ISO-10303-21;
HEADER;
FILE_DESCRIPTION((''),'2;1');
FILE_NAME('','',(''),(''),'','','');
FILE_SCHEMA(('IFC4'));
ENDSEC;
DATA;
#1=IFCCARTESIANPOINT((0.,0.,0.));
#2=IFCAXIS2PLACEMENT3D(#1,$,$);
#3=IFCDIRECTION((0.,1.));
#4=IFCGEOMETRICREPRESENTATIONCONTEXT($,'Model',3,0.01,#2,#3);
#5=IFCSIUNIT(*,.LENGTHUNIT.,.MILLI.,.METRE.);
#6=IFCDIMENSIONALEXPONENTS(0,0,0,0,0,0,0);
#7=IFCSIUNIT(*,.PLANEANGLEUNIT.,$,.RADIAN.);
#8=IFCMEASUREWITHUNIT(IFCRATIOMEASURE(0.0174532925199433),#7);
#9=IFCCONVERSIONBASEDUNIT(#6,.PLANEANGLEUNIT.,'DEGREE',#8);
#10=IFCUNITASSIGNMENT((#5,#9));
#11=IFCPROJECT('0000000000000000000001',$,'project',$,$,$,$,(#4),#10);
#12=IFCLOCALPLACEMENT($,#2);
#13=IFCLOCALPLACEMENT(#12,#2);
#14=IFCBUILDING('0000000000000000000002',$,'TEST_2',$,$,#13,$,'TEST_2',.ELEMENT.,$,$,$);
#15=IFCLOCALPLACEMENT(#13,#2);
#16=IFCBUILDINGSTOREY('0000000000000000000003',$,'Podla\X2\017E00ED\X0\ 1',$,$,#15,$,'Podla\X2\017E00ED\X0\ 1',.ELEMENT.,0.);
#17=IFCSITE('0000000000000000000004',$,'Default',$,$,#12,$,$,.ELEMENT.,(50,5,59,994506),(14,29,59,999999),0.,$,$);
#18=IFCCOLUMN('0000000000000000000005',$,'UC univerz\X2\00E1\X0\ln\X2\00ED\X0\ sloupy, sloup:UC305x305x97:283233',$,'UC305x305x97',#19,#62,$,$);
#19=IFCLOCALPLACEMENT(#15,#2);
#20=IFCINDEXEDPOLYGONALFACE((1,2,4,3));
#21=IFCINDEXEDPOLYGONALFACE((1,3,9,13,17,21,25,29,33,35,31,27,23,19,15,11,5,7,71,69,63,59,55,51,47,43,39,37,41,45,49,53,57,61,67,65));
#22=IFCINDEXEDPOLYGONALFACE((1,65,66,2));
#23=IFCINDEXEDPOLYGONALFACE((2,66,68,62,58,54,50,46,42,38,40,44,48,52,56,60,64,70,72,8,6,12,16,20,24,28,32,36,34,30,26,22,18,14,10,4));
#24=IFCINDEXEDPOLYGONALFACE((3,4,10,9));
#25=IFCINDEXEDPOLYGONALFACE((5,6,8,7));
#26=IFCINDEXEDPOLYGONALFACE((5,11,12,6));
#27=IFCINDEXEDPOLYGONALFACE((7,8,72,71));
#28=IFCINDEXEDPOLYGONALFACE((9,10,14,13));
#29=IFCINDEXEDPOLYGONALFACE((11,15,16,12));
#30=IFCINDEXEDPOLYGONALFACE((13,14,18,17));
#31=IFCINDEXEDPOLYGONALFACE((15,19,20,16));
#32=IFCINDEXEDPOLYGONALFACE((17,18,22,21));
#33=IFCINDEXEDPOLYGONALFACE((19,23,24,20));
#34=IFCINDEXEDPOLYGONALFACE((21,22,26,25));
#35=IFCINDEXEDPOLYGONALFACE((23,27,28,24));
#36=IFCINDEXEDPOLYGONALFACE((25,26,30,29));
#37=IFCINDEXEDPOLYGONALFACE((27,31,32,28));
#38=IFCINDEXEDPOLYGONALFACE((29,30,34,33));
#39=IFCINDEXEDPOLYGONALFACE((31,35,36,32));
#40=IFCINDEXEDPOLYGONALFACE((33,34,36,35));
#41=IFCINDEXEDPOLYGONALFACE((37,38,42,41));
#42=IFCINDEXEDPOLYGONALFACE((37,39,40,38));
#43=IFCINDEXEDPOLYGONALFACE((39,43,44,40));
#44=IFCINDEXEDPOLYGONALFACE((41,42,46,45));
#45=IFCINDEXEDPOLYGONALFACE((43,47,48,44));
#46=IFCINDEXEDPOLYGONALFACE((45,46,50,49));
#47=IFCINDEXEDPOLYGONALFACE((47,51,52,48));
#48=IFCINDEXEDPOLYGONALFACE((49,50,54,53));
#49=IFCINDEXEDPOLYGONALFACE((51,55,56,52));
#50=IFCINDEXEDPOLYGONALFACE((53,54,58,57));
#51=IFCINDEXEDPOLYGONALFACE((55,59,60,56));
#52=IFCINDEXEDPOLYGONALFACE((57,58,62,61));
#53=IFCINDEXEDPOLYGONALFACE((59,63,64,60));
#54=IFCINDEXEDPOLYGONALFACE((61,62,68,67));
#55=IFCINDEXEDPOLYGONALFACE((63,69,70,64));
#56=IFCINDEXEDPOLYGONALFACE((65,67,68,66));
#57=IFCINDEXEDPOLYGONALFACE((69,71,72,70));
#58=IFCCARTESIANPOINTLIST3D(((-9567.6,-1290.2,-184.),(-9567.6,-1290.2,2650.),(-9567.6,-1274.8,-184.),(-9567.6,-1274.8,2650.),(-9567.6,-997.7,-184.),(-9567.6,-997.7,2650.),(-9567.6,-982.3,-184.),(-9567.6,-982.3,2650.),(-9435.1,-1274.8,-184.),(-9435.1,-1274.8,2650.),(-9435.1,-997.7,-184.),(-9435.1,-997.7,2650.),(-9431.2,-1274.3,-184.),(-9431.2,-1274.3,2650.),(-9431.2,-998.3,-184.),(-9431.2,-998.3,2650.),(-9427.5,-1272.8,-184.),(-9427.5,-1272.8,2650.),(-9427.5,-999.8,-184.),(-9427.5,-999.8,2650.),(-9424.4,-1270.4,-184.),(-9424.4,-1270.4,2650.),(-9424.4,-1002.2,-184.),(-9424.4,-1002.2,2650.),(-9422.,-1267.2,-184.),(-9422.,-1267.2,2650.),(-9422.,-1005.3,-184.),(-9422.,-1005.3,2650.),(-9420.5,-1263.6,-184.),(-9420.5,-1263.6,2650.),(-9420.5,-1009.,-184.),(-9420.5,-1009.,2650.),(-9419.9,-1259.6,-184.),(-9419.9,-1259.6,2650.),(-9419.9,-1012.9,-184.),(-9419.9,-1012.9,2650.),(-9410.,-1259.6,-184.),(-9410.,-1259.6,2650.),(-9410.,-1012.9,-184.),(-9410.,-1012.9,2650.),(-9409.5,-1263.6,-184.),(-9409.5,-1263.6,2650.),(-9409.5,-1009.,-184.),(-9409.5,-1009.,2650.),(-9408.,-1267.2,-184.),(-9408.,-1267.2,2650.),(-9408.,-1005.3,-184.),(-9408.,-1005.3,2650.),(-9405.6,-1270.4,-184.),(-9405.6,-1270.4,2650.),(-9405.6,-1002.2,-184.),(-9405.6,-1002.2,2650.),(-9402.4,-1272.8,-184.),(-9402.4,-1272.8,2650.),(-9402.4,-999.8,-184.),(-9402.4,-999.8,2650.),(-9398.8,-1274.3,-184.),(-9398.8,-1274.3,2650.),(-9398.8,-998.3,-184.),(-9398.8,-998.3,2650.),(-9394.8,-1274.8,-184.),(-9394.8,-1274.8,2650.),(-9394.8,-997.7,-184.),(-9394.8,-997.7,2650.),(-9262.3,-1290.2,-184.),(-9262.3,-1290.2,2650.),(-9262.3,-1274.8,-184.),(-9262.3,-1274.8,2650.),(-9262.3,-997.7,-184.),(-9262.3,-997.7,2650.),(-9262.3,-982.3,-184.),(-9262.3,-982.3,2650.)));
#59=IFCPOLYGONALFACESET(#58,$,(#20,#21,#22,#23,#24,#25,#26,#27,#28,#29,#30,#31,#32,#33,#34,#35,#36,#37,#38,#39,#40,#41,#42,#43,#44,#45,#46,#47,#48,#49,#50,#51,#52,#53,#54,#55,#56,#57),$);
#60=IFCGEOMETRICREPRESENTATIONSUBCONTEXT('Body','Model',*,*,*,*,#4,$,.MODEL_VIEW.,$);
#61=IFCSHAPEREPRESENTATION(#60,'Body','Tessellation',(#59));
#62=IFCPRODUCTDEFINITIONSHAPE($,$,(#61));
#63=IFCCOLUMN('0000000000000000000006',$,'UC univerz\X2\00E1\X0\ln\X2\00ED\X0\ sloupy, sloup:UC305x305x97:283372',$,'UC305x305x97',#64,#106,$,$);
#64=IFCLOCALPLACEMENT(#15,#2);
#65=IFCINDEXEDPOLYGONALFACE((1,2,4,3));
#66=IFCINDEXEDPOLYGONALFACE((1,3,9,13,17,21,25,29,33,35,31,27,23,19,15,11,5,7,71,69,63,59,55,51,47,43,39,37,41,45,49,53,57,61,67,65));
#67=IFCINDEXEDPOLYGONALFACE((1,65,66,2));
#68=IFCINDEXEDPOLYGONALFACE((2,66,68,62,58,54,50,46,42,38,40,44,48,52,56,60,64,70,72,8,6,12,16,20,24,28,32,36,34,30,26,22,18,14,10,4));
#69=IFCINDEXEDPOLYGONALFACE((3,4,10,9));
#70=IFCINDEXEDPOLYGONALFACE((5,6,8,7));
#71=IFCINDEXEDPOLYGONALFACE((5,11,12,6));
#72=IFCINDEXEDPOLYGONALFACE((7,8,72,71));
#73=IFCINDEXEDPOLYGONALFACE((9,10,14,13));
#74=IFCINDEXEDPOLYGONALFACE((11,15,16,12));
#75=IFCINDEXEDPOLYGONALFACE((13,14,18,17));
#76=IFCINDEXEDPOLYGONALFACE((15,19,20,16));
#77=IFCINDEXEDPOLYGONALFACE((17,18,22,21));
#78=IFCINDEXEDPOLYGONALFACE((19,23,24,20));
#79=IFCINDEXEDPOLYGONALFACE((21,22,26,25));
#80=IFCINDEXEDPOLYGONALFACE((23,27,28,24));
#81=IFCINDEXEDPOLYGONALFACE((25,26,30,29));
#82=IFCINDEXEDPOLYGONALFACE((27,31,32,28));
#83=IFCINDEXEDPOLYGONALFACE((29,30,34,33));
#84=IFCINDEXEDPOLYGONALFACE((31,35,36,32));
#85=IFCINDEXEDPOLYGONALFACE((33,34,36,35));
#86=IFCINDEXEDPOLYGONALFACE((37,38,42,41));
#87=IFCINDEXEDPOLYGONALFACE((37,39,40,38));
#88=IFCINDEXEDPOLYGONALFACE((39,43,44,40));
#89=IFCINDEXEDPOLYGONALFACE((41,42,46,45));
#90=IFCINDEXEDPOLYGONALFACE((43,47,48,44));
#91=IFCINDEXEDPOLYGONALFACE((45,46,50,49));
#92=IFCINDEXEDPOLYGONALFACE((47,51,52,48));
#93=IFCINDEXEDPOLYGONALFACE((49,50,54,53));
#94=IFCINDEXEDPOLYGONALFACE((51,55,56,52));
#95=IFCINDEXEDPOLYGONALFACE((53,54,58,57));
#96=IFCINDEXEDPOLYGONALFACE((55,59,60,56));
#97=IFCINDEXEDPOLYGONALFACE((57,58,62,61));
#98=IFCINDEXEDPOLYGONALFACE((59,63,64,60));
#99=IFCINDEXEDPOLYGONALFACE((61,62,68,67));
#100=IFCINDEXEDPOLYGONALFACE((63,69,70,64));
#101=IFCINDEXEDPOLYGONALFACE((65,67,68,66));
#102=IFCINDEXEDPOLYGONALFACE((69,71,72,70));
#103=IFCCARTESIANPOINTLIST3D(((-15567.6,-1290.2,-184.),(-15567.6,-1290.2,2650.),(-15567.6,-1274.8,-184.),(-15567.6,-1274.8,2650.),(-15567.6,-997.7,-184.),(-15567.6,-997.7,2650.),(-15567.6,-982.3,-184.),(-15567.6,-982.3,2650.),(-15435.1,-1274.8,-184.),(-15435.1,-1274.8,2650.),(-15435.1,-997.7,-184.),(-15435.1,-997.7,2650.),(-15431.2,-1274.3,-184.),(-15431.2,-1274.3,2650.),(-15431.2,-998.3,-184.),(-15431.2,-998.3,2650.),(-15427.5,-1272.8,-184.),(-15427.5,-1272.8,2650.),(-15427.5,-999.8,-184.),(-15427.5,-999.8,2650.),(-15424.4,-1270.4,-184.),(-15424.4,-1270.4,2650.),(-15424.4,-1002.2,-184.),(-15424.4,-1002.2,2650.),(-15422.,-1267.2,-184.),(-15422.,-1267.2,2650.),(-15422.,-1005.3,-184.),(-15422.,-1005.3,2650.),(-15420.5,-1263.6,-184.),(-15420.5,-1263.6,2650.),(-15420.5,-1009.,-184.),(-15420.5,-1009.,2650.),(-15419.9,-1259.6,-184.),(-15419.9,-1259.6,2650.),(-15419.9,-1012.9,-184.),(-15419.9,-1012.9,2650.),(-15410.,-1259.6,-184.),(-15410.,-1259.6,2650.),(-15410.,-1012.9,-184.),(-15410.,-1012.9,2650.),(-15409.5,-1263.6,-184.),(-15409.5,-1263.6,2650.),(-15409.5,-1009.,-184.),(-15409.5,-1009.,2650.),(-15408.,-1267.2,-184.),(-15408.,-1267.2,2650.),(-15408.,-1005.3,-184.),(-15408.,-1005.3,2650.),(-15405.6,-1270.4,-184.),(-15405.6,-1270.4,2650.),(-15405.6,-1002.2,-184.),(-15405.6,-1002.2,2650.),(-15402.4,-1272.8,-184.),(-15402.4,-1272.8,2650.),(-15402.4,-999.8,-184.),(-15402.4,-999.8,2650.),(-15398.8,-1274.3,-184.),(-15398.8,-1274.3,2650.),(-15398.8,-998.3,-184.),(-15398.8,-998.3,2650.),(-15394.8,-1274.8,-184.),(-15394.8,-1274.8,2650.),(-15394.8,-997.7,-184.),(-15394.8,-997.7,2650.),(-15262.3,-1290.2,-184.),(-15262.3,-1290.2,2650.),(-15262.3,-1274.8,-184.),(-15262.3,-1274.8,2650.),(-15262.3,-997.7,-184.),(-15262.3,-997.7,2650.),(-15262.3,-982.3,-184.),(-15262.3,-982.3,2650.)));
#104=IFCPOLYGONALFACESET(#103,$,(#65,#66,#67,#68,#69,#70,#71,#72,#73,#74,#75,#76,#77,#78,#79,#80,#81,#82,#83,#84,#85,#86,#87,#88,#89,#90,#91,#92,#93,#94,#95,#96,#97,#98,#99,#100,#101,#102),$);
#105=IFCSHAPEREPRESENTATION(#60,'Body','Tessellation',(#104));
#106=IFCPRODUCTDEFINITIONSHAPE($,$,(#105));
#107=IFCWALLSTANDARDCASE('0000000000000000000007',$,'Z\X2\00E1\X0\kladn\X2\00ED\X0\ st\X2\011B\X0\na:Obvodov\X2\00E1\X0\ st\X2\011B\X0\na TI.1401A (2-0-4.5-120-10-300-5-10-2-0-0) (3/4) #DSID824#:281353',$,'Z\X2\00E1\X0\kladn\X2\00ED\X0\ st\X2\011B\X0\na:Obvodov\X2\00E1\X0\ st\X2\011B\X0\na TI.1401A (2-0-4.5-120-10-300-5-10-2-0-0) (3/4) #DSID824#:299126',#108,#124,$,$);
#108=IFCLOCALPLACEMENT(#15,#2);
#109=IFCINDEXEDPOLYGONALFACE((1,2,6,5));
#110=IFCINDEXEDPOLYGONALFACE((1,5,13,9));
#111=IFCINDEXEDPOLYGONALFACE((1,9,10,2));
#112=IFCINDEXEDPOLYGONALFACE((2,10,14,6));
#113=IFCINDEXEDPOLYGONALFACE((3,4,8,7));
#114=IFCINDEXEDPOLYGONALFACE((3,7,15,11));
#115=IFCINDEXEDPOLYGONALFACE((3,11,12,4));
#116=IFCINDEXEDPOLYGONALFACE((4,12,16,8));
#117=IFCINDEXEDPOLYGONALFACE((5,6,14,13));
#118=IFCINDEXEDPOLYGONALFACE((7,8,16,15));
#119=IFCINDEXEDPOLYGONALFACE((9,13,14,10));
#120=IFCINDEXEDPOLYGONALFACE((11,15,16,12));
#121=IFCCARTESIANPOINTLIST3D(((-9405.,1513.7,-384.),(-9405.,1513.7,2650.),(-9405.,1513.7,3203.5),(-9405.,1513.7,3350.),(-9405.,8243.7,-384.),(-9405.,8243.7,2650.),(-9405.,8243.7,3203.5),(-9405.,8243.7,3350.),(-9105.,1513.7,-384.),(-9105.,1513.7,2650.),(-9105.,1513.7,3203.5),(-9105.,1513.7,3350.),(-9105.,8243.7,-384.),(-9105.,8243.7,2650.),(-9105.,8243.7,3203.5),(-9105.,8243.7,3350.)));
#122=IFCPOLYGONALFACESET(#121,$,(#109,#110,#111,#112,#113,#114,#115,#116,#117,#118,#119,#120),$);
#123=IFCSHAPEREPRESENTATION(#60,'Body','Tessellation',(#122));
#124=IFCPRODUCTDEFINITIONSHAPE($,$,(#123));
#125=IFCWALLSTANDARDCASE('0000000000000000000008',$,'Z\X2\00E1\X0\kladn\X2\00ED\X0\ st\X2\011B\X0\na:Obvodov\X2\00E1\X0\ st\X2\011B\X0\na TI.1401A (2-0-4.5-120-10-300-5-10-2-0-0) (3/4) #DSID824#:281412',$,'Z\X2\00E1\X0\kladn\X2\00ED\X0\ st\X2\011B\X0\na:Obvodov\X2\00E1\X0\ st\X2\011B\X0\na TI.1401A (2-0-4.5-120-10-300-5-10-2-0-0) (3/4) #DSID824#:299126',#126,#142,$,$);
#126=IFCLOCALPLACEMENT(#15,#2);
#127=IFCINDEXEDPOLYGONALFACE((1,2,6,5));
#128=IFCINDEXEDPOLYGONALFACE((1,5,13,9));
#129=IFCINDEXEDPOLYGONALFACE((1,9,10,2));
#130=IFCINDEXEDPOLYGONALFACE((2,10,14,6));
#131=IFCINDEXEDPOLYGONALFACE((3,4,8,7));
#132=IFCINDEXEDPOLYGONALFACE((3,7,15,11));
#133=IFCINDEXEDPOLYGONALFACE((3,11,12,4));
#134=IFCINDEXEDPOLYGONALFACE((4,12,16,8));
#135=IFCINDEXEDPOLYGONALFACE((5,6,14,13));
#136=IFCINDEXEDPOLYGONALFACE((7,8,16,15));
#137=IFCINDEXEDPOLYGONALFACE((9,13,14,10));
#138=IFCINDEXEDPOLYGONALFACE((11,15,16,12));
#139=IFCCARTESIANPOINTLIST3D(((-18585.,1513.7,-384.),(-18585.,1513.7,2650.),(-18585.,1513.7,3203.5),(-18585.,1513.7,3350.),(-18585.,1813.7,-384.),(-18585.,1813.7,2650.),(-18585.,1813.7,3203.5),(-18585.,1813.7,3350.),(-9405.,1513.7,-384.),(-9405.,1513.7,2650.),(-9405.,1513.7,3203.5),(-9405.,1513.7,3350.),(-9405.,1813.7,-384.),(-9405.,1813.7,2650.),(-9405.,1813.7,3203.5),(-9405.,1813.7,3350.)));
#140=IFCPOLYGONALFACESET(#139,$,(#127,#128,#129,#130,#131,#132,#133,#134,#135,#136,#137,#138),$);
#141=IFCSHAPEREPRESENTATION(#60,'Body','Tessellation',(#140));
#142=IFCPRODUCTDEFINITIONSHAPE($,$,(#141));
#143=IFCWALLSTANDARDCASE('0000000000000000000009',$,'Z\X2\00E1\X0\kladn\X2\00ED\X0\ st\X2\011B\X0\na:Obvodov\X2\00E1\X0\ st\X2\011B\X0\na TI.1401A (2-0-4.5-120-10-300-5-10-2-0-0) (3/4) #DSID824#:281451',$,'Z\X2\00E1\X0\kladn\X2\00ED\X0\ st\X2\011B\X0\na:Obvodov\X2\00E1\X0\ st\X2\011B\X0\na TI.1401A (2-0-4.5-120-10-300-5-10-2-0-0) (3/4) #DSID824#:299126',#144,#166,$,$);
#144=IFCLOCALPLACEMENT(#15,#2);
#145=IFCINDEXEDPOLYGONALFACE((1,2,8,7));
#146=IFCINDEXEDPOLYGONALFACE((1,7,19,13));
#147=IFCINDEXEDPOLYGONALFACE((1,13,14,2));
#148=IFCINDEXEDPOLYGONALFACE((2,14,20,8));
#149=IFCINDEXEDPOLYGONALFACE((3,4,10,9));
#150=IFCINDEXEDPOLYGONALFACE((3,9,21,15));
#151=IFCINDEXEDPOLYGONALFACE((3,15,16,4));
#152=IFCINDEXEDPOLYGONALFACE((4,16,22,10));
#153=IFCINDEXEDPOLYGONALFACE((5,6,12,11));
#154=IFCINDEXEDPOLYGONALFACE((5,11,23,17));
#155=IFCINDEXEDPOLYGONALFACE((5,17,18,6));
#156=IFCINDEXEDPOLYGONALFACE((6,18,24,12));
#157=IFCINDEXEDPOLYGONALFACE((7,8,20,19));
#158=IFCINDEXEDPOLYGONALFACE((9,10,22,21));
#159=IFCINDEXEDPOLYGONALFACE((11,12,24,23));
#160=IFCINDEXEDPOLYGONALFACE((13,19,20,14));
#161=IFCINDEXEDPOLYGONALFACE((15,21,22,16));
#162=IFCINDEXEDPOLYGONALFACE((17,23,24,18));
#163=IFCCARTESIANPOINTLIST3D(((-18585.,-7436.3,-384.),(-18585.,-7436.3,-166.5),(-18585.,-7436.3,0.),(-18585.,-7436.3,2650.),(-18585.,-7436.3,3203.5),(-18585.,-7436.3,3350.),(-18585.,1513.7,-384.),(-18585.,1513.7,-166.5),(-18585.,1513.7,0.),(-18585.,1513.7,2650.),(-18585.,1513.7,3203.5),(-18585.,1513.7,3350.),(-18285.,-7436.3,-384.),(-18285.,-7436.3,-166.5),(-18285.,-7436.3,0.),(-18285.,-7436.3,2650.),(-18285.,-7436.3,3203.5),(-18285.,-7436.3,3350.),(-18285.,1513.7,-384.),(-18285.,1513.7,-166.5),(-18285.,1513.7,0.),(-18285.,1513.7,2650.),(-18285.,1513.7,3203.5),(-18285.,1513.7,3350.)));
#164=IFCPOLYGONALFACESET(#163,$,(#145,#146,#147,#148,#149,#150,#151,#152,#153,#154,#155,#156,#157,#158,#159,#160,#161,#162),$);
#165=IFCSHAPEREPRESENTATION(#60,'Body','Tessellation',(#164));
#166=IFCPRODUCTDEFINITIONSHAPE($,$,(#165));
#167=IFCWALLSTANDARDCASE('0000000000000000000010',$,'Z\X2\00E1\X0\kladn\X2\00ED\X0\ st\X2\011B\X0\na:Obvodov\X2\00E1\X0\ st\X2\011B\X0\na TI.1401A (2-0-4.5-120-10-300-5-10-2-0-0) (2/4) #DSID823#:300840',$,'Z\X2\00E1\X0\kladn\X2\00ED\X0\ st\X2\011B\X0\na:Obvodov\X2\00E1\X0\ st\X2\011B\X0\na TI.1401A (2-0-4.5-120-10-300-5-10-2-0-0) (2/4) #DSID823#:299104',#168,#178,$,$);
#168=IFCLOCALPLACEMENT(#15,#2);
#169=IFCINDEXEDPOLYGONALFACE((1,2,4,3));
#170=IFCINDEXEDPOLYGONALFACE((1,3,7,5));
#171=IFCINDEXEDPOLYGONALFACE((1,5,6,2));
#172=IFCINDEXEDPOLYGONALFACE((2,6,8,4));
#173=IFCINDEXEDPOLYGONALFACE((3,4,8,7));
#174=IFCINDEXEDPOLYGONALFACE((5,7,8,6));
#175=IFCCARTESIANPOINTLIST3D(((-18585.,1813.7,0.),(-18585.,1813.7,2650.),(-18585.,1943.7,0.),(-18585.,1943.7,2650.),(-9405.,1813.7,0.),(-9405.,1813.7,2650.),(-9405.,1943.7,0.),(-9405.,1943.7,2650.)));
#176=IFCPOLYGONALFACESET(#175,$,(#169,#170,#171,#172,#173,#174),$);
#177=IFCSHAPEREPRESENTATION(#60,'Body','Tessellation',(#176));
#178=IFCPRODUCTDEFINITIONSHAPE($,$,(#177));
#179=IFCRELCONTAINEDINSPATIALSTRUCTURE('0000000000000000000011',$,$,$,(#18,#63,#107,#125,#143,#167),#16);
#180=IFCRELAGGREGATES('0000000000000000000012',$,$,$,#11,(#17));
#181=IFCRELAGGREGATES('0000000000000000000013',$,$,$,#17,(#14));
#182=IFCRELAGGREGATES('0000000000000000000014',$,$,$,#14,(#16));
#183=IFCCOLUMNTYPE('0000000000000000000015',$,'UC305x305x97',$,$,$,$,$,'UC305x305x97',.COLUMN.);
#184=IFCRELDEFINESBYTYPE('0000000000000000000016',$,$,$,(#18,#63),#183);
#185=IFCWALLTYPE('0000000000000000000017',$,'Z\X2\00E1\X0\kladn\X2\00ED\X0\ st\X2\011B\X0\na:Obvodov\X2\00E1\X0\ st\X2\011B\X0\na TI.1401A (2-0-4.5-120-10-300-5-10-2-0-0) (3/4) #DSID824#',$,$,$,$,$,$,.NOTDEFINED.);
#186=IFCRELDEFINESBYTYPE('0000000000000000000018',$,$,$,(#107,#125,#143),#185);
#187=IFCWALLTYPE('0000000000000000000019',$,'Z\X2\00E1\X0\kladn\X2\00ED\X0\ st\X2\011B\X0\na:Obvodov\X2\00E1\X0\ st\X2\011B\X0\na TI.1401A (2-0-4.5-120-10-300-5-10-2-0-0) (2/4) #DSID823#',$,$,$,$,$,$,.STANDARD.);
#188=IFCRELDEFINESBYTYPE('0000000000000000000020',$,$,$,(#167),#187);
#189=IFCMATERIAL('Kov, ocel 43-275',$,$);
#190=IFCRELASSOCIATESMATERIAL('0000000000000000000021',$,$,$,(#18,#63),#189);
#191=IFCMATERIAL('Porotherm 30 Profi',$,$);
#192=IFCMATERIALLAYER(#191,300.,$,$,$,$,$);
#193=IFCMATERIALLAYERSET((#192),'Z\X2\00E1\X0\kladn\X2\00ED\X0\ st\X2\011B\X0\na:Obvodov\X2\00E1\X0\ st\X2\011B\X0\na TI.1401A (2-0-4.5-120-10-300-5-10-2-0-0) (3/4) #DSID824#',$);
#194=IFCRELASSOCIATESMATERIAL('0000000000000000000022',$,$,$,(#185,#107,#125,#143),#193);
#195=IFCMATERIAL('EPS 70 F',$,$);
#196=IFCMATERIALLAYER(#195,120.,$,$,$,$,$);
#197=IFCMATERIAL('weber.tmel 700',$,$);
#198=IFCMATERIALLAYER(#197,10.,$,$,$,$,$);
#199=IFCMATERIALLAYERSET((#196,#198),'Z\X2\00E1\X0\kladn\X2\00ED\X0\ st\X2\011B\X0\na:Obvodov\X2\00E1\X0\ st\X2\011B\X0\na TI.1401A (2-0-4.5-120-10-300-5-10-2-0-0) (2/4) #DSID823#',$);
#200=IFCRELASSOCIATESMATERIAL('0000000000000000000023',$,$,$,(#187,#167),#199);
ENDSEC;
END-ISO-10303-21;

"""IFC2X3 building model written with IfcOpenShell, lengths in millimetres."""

from ifc_helpers import new_model, entity, si_unit, converted_unit, direction, frame, frame_2d, origin, origin_2d_with_axis, place, context, subcontext, project, spatial, rectangle, i_section, extrude, source, transform, mapped, material, layer, layer_set, layer_usage, type_object, type_shapes, element, save


model = new_model("IFC2X3")

# Units and contexts
model_context = context("Model", 3, precision=0.01, world=origin(), true_north=direction((0.0, 1.0)))
body_context = subcontext(model_context, "Body", "Model", "MODEL_VIEW")
ifc_project = project(units=[si_unit("LENGTHUNIT", "METRE", prefix="MILLI"), converted_unit("PLANEANGLEUNIT", "DEGREE", entity("IfcRatioMeasure", 0.0174532925199433), si_unit("PLANEANGLEUNIT", "RADIAN"), dimensions=[0, 0, 0, 0, 0, 0, 0])], contexts=[model_context])

# Site, building, storey
site_placement = place(None, origin())
site = spatial("IfcSite", under=ifc_project, at=site_placement, Name="Default", CompositionType="ELEMENT", RefLatitude=(50, 5, 59, 994506), RefLongitude=(14, 29, 59, 999999), RefElevation=0.0)
building_placement = place(site_placement, origin())
building = spatial("IfcBuilding", under=site, at=building_placement, Name="TEST_2", LongName="TEST_2", CompositionType="ELEMENT")
storey_placement = place(building_placement, origin())
storey = spatial("IfcBuildingStorey", under=building, at=storey_placement, Name="Podlaží 1", LongName="Podlaží 1", CompositionType="ELEMENT", Elevation=0.0)

# Columns
ifc_material_1 = material(Name="Kov, ocel 43-275")
column_type = type_object("IfcColumnType", Name="UC305x305x97", ElementType="UC305x305x97", PredefinedType="COLUMN")
shared_shape_1 = source(origin(), body_context, "Body", "SweptSolid", [
    extrude(i_section(OverallWidth=305.3, OverallDepth=307.9, WebThickness=9.9, FlangeThickness=15.4, FilletRadius=15.2, at=origin_2d_with_axis()), frame((0.0, 0.0, -184.0), z_axis=(0.0, 0.0, 1.0), x_axis=(-1.0, 0.0, 0.0)), (0.0, 0.0, 1.0), 2834.0),
])
type_shapes(column_type, [shared_shape_1])
for number, where, name in (
    (1, (-9415.0, -1136.3, 0.0), "UC univerzální sloupy, sloup:UC305x305x97:283233"),
    (2, (-15415.0, -1136.3, 0.0), "UC univerzální sloupy, sloup:UC305x305x97:283372"),
):
    element("IfcColumn", number, at=place(storey_placement, frame(where)), inside=storey, type_object=column_type, material=ifc_material_1, Name=name, ObjectType="UC305x305x97", context=body_context, shape_type="MappedRepresentation", body=[
        mapped(shared_shape_1, transform((0.0, 0.0, 0.0), scale=1.0)),
    ])

# Walls, openings
ifc_material_2 = material(Name="Porotherm 30 Profi")
ifc_layer_1 = layer(ifc_material_2, 300.0)
ifc_layer_set_1 = layer_set([ifc_layer_1], Name="Základní stěna:Obvodová stěna TI.1401A (2-0-4.5-120-10-300-5-10-2-0-0) (3/4) #DSID824#")
ifc_layer_usage_1 = layer_usage(ifc_layer_set_1, "AXIS2", "POSITIVE", -150.0)
wall_type_1 = type_object("IfcWallType", Name="Základní stěna:Obvodová stěna TI.1401A (2-0-4.5-120-10-300-5-10-2-0-0) (3/4) #DSID824#", PredefinedType="NOTDEFINED", material=ifc_layer_set_1)
wall_1_placement = place(storey_placement, frame((-9255.0, 8243.7, -384.0), z_axis=(0.0, 0.0, 1.0), x_axis=(0.0, -1.0, 0.0)))
wall_1 = element("IfcWallStandardCase", 3, at=wall_1_placement, inside=storey, type_object=wall_type_1, material=ifc_layer_usage_1, Name="Základní stěna:Obvodová stěna TI.1401A (2-0-4.5-120-10-300-5-10-2-0-0) (3/4) #DSID824#:281353", ObjectType="Základní stěna:Obvodová stěna TI.1401A (2-0-4.5-120-10-300-5-10-2-0-0) (3/4) #DSID824#:299126", context=body_context, shape_type="SweptSolid", body=[
    extrude(rectangle(XDim=6730.0, YDim=300.0, at=frame_2d((3365.0, 0.0), x_axis=(-1.0, 0.0))), origin(), (0.0, 0.0, 1.0), 3734.0),
])
opening_1_placement = place(storey_placement, frame((-9255.0, 8243.7, -384.0), z_axis=(0.0, 0.0, 1.0), x_axis=(0.0, -1.0, 0.0)))
element("IfcOpeningElement", 4, at=opening_1_placement, cuts=wall_1, ObjectType="Opening", context=body_context, shape_type="SweptSolid", body=[
    extrude(rectangle(XDim=6730.0, YDim=300.0, at=frame_2d((-613.0, 30.0), x_axis=(1.0, 0.0))), frame((3978.0, -30.0, 3034.0)), (0.0, 0.0, 1.0), 553.5),
])
ifc_layer_usage_2 = layer_usage(ifc_layer_set_1, "AXIS2", "POSITIVE", -150.0)
wall_2_placement = place(storey_placement, frame((-9405.0, 1663.7, -384.0), z_axis=(0.0, 0.0, 1.0), x_axis=(-1.0, 0.0, 0.0)))
wall_2 = element("IfcWallStandardCase", 5, at=wall_2_placement, inside=storey, type_object=wall_type_1, material=ifc_layer_usage_2, Name="Základní stěna:Obvodová stěna TI.1401A (2-0-4.5-120-10-300-5-10-2-0-0) (3/4) #DSID824#:281412", ObjectType="Základní stěna:Obvodová stěna TI.1401A (2-0-4.5-120-10-300-5-10-2-0-0) (3/4) #DSID824#:299126", context=body_context, shape_type="SweptSolid", body=[
    extrude(rectangle(XDim=9180.0, YDim=300.0, at=frame_2d((4590.0, 0.0), x_axis=(-1.0, 0.0))), origin(), (0.0, 0.0, 1.0), 3734.0),
])
opening_2_placement = place(storey_placement, frame((-9405.0, 1663.7, -384.0), z_axis=(0.0, 0.0, 1.0), x_axis=(-1.0, 0.0, 0.0)))
element("IfcOpeningElement", 6, at=opening_2_placement, cuts=wall_2, ObjectType="Opening", context=body_context, shape_type="SweptSolid", body=[
    extrude(rectangle(XDim=9180.0, YDim=300.0, at=frame_2d((-858.0, -30.0), x_axis=(1.0, 0.0))), frame((5448.0, 30.0, 3034.0)), (0.0, 0.0, 1.0), 553.5),
])

# Wall, openings
ifc_layer_usage_3 = layer_usage(ifc_layer_set_1, "AXIS2", "POSITIVE", -150.0)
wall_3_placement = place(storey_placement, frame((-18435.0, 1513.7, -384.0), z_axis=(0.0, 0.0, 1.0), x_axis=(0.0, -1.0, 0.0)))
wall_3 = element("IfcWallStandardCase", 7, at=wall_3_placement, inside=storey, type_object=wall_type_1, material=ifc_layer_usage_3, Name="Základní stěna:Obvodová stěna TI.1401A (2-0-4.5-120-10-300-5-10-2-0-0) (3/4) #DSID824#:281451", ObjectType="Základní stěna:Obvodová stěna TI.1401A (2-0-4.5-120-10-300-5-10-2-0-0) (3/4) #DSID824#:299126", context=body_context, shape_type="SweptSolid", body=[
    extrude(rectangle(XDim=8950.0, YDim=300.0, at=frame_2d((4475.0, 0.0), x_axis=(-1.0, 0.0))), origin(), (0.0, 0.0, 1.0), 3734.0),
])
opening_3_placement = place(storey_placement, frame((-18435.0, 1513.7, -384.0), z_axis=(0.0, 0.0, 1.0), x_axis=(0.0, -1.0, 0.0)))
element("IfcOpeningElement", 8, at=opening_3_placement, cuts=wall_3, ObjectType="Opening", context=body_context, shape_type="SweptSolid", body=[
    extrude(rectangle(XDim=8950.0, YDim=300.0, at=origin_2d_with_axis()), frame((4475.0, 0.0, 217.5)), (0.0, 0.0, 1.0), 166.5),
])
opening_4_placement = place(storey_placement, frame((-18435.0, 1513.7, -384.0), z_axis=(0.0, 0.0, 1.0), x_axis=(0.0, -1.0, 0.0)))
element("IfcOpeningElement", 9, at=opening_4_placement, cuts=wall_3, ObjectType="Opening", context=body_context, shape_type="SweptSolid", body=[
    extrude(rectangle(XDim=8950.0, YDim=300.0, at=origin_2d_with_axis()), frame((4475.0, 0.0, 3034.0), z_axis=(0.0, 0.0, 1.0), x_axis=(-1.0, 0.0, 0.0)), (0.0, 0.0, 1.0), 553.5),
])
ifc_material_3 = material(Name="EPS 70 F")
ifc_layer_2 = layer(ifc_material_3, 120.0)
ifc_material_4 = material(Name="weber.tmel 700")
ifc_layer_3 = layer(ifc_material_4, 10.0)
ifc_layer_set_2 = layer_set([ifc_layer_2, ifc_layer_3], Name="Základní stěna:Obvodová stěna TI.1401A (2-0-4.5-120-10-300-5-10-2-0-0) (2/4) #DSID823#")
wall_type_2 = type_object("IfcWallType", Name="Základní stěna:Obvodová stěna TI.1401A (2-0-4.5-120-10-300-5-10-2-0-0) (2/4) #DSID823#", PredefinedType="STANDARD", material=ifc_layer_set_2)

# Wall
ifc_layer_usage_4 = layer_usage(ifc_layer_set_2, "AXIS2", "NEGATIVE", 65.0)
wall_4_placement = place(storey_placement, frame((-18585.0, 1878.7, 0.0)))
element("IfcWallStandardCase", 10, at=wall_4_placement, inside=storey, type_object=wall_type_2, material=ifc_layer_usage_4, Name="Základní stěna:Obvodová stěna TI.1401A (2-0-4.5-120-10-300-5-10-2-0-0) (2/4) #DSID823#:300840", ObjectType="Základní stěna:Obvodová stěna TI.1401A (2-0-4.5-120-10-300-5-10-2-0-0) (2/4) #DSID823#:299104", context=body_context, shape_type="SweptSolid", body=[
    extrude(rectangle(XDim=9180.0, YDim=130.0, at=frame_2d((4590.0, 0.0), x_axis=(-1.0, 0.0))), origin(), (0.0, 0.0, 1.0), 2650.0),
])

save(model, "model.ifc")
